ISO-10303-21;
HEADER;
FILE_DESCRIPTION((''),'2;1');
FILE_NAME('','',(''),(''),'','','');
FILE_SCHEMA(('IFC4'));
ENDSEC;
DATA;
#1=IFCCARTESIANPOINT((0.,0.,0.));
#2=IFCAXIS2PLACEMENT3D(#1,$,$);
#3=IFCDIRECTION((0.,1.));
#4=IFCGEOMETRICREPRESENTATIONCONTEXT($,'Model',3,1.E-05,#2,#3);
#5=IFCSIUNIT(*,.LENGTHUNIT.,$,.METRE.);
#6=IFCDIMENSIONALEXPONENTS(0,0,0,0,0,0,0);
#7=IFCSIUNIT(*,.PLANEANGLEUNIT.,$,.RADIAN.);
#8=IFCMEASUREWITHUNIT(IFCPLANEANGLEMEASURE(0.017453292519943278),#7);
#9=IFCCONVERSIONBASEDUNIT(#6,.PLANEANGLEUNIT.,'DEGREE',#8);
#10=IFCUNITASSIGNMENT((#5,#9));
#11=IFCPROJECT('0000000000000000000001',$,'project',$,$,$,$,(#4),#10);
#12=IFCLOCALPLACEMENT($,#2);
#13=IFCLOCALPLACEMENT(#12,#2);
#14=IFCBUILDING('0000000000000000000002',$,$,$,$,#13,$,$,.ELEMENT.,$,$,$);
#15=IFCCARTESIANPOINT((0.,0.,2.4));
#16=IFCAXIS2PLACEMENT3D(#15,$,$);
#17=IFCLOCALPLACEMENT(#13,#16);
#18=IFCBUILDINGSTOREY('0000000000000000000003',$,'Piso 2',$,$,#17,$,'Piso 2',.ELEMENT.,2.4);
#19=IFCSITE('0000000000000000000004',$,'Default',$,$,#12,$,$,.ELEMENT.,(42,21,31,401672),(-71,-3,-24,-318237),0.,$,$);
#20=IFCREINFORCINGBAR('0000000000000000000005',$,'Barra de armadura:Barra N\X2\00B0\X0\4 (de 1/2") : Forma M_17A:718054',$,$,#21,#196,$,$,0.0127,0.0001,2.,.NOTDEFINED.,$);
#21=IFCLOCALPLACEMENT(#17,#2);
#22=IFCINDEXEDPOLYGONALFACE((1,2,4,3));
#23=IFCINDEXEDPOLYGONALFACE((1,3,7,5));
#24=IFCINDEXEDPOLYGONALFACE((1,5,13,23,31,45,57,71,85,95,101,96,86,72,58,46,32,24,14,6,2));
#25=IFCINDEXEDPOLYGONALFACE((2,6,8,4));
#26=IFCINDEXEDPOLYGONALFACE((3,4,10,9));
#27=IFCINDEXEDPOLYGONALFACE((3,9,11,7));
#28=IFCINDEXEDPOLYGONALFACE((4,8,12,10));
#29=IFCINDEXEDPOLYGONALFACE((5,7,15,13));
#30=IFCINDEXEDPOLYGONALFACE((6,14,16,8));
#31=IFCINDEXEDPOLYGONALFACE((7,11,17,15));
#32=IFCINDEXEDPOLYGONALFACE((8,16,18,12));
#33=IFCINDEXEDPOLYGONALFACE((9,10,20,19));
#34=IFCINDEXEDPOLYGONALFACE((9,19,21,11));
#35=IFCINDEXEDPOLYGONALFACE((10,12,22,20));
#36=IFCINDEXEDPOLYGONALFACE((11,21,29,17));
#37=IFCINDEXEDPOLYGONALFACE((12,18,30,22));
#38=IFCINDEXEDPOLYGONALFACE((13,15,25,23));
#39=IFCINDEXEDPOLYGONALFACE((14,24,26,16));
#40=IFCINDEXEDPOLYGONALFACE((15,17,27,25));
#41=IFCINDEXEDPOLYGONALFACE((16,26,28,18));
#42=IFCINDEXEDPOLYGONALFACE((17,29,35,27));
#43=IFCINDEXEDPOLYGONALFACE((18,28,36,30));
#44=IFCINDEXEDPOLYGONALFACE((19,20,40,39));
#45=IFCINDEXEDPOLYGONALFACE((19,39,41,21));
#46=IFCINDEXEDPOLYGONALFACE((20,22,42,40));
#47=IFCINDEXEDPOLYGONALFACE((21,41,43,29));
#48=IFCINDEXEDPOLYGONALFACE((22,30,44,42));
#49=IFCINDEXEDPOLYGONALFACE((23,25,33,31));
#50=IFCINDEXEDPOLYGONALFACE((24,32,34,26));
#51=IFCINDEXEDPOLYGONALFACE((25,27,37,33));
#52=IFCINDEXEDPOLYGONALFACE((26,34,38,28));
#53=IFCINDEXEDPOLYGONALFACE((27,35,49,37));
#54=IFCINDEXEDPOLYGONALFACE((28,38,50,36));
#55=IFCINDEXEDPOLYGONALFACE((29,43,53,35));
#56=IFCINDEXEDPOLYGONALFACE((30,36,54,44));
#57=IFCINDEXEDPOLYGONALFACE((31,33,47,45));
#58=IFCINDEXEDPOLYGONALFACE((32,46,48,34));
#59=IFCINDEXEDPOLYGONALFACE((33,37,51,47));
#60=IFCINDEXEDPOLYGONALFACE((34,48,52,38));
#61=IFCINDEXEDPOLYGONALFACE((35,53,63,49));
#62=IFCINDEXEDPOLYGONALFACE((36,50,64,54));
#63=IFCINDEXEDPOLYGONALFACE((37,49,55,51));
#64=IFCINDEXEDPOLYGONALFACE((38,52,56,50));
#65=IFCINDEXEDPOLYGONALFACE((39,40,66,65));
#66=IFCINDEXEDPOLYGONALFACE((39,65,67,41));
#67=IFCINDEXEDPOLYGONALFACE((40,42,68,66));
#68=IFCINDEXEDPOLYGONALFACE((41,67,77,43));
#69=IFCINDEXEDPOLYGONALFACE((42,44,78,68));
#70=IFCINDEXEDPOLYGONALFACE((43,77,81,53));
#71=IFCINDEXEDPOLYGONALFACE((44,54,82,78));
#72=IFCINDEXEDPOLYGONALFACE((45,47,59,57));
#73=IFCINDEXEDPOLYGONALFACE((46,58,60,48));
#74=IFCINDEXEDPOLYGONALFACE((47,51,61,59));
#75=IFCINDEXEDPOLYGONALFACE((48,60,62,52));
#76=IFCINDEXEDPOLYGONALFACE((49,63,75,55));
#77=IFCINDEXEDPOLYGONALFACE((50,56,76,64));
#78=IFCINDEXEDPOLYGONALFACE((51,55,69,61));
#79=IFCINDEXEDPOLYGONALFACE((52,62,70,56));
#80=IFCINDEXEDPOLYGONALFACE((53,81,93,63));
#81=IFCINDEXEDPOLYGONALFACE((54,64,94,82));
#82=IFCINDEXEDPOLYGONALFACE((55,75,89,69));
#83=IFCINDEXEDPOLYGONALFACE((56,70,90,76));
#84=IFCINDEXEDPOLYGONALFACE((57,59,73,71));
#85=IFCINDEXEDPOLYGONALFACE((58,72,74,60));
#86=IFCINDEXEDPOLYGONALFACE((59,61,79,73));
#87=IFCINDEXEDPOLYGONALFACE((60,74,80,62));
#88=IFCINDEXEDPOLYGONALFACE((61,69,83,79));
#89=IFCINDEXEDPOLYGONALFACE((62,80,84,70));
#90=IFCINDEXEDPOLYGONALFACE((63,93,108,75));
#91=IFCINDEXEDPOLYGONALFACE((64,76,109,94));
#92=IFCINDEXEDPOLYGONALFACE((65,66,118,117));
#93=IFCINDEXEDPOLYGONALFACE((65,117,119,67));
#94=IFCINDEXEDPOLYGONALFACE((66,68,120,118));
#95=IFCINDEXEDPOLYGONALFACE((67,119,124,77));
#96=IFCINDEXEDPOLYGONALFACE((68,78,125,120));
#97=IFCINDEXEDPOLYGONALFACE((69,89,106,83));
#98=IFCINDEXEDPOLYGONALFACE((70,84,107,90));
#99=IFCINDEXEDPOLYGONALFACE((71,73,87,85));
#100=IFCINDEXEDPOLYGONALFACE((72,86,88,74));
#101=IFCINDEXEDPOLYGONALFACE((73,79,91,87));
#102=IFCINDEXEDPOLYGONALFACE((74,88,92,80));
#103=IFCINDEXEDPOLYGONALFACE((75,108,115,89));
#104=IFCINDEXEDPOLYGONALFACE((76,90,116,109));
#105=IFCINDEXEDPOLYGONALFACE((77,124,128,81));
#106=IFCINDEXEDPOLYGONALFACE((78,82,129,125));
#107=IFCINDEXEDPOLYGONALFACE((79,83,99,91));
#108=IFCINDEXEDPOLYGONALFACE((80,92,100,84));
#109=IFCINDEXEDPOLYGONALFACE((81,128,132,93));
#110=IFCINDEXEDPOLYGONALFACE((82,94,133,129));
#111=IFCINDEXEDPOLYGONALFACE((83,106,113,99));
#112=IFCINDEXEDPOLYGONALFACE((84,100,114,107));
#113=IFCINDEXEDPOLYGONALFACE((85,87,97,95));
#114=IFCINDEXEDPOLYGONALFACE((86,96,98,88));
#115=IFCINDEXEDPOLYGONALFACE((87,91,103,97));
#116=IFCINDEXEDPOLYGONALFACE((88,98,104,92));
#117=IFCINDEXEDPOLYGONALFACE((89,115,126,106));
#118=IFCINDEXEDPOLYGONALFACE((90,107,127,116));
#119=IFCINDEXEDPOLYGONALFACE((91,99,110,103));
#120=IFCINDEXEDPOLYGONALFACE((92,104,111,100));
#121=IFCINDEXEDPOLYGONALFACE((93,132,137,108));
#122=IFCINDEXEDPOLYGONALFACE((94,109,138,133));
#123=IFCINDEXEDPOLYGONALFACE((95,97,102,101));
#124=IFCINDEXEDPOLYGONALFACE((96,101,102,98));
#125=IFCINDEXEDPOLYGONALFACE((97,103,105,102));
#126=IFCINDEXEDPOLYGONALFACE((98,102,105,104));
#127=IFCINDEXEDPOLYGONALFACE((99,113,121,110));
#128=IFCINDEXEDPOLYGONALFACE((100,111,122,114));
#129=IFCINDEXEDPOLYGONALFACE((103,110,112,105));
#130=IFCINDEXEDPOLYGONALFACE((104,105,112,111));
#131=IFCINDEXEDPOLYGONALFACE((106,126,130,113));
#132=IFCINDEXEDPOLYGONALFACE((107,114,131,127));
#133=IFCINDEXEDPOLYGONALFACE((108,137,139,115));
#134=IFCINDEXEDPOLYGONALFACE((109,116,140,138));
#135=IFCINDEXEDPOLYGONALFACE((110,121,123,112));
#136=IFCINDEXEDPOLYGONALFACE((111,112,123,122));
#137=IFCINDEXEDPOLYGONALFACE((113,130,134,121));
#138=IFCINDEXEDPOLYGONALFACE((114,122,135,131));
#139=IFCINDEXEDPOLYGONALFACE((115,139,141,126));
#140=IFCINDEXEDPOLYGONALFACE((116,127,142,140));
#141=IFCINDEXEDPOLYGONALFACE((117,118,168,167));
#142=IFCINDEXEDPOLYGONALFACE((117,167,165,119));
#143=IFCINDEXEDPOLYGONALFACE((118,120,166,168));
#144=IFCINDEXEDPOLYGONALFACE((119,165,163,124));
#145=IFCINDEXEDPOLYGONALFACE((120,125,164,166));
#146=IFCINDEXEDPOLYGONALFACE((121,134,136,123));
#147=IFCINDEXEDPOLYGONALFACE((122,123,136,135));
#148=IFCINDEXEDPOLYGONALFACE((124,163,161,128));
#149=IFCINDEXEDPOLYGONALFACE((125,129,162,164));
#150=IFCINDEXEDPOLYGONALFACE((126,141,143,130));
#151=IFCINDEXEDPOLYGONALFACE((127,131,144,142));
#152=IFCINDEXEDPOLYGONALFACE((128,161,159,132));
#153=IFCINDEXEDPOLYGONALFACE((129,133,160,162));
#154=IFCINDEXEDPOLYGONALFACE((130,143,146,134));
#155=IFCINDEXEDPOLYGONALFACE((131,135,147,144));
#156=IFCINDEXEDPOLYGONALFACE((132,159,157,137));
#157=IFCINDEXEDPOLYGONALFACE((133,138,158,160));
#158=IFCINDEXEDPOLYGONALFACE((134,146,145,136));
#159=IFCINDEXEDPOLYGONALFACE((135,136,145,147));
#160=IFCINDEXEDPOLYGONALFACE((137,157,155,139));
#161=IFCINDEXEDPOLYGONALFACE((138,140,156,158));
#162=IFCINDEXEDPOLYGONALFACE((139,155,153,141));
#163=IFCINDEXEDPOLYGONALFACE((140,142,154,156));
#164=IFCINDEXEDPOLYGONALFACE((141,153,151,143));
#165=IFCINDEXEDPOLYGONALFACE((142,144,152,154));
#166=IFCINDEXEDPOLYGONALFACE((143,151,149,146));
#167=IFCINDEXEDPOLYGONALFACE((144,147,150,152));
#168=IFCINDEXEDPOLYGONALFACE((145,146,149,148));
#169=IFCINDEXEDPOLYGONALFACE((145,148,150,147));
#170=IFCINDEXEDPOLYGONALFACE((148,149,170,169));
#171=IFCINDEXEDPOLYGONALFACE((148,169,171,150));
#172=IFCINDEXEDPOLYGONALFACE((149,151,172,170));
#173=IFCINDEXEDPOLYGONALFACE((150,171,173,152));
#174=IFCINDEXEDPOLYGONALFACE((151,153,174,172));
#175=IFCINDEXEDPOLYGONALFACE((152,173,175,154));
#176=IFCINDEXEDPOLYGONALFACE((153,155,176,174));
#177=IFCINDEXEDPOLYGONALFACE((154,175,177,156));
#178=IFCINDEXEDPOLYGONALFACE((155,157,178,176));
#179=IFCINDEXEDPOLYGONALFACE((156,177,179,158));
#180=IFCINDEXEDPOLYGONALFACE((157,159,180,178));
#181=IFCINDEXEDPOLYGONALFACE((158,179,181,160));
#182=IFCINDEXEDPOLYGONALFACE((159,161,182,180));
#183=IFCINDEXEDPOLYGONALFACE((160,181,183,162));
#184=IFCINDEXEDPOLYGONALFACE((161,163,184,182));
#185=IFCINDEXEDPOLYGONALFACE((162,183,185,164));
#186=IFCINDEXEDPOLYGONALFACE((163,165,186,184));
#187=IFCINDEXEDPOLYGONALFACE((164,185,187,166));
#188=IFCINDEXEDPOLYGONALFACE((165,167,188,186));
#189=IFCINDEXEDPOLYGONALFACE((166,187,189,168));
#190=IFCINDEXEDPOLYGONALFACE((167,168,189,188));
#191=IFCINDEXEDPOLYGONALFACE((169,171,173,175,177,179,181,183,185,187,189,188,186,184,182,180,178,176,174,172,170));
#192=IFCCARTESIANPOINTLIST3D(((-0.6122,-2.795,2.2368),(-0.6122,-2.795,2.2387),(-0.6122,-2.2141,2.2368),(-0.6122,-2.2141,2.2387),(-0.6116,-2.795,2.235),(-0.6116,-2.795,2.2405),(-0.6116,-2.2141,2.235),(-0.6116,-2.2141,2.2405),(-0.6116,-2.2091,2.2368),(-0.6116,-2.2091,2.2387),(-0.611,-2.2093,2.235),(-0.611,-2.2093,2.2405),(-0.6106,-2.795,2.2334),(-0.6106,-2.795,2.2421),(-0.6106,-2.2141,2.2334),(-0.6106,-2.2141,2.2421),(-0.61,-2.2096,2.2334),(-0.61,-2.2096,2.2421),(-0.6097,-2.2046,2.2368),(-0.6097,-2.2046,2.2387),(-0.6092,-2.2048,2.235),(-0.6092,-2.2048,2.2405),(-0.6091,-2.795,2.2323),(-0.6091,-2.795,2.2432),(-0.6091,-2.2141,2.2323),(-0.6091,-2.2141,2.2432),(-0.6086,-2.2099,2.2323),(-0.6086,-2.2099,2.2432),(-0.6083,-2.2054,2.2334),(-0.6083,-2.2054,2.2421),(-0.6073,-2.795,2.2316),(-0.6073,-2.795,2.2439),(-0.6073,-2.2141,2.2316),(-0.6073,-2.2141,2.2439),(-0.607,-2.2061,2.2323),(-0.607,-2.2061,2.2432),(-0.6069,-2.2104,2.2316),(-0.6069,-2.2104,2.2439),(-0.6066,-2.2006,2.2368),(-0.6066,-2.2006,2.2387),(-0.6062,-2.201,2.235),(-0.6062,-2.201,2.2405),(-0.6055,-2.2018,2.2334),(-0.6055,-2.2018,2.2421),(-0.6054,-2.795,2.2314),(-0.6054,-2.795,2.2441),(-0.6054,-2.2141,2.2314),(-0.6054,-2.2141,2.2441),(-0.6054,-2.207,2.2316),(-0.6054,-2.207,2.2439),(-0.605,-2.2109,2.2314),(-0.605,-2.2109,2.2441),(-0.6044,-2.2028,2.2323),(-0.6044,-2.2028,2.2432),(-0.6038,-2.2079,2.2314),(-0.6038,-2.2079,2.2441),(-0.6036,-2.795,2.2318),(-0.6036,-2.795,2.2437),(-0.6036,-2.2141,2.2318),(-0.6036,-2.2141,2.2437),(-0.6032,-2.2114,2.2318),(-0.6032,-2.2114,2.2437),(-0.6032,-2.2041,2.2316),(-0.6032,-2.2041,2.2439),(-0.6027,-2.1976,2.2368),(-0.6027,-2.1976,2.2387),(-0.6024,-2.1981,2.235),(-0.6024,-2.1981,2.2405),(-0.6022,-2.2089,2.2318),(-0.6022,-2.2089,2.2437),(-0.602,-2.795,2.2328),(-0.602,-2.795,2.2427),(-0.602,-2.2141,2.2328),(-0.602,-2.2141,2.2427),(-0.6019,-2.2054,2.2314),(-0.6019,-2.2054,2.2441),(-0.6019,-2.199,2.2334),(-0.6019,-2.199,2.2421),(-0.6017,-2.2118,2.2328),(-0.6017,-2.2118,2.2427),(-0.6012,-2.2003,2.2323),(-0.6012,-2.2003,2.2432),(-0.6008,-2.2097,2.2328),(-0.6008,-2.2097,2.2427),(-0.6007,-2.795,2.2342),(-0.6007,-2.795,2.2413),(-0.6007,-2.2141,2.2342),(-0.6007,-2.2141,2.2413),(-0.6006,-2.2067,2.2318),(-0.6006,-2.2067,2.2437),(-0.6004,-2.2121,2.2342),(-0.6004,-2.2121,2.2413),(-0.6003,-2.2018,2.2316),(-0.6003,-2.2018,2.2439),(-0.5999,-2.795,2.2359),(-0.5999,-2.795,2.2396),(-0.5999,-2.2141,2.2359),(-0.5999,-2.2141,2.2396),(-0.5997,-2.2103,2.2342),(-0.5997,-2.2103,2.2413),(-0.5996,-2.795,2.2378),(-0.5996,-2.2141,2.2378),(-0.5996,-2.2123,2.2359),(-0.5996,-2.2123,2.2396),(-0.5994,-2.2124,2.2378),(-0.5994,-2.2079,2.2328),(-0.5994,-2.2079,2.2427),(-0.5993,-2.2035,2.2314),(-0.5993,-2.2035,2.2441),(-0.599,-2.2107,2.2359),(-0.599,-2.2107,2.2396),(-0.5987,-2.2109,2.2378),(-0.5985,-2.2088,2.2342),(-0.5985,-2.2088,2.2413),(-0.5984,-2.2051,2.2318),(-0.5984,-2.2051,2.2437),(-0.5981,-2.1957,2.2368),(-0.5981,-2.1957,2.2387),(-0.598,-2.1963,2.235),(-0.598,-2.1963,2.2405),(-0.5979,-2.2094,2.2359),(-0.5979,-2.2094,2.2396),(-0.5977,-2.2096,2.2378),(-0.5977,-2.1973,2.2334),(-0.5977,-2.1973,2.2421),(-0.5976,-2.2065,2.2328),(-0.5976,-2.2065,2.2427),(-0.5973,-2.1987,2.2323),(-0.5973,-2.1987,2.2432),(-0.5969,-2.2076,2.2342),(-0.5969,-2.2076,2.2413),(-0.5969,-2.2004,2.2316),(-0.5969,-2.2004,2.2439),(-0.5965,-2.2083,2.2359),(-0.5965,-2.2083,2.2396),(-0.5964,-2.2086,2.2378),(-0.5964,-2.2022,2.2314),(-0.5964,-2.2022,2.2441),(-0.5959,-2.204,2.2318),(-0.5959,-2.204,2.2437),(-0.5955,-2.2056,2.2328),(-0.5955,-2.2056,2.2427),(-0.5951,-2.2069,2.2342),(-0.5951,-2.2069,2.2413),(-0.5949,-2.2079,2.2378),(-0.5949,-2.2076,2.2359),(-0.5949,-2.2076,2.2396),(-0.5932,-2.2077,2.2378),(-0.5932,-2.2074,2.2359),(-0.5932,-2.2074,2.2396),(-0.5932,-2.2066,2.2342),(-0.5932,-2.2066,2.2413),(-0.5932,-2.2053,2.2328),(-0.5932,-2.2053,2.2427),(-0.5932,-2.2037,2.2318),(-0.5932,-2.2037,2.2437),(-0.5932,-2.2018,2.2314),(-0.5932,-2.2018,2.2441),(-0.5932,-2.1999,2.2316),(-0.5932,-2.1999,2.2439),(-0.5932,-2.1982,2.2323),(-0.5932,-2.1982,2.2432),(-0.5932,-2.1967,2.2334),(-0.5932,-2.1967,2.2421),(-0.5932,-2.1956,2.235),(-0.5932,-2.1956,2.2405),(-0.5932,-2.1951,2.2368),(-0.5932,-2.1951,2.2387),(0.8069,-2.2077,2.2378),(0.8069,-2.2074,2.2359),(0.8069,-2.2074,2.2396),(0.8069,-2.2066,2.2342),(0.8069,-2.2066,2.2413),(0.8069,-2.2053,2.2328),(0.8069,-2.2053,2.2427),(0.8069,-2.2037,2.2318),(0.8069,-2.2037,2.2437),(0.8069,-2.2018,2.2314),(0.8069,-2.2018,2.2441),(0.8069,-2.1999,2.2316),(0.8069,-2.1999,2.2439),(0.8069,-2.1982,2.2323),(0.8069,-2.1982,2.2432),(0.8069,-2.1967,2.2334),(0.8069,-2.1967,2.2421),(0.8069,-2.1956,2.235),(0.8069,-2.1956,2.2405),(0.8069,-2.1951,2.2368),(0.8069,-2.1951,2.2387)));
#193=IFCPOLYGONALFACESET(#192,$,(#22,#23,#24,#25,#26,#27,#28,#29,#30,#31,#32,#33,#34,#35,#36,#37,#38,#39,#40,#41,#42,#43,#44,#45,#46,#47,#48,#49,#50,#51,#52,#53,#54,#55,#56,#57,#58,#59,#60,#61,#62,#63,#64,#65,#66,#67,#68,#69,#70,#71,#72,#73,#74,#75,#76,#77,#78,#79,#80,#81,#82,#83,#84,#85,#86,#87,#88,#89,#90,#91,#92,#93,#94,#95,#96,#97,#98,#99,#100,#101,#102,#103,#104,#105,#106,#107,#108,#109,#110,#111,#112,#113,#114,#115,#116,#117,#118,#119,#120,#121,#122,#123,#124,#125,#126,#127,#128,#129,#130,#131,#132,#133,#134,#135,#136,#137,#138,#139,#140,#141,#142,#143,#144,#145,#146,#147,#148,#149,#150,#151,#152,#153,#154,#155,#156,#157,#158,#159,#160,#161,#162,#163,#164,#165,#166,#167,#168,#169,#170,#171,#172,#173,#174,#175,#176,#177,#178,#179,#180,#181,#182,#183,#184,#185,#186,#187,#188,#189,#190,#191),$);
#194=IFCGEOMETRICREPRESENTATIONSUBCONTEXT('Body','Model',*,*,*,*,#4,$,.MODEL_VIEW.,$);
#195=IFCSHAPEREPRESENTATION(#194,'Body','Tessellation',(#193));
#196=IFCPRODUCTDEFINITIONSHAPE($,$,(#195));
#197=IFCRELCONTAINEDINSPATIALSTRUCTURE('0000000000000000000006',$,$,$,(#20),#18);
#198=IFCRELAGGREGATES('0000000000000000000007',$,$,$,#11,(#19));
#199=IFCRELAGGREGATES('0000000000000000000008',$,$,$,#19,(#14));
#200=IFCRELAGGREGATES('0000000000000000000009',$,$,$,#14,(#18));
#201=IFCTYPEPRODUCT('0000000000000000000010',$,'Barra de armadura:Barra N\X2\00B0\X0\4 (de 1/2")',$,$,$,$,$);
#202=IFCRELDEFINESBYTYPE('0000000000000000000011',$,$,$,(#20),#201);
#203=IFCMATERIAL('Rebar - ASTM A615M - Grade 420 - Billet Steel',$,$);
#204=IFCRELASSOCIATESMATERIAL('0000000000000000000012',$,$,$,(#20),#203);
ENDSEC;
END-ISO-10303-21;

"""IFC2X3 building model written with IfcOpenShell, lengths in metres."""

from ifc_helpers import new_model, entity, si_unit, converted_unit, direction, frame, origin, place, context, subcontext, project, spatial, material, type_object, element, save


model = new_model("IFC2X3")

# Units and contexts
model_context = context("Model", 3, precision=1e-05, world=origin(), true_north=direction((0.0, 1.0)))
body_context = subcontext(model_context, "Body", "Model", "MODEL_VIEW")
ifc_project = project(units=[si_unit("LENGTHUNIT", "METRE"), converted_unit("PLANEANGLEUNIT", "DEGREE", entity("IfcPlaneAngleMeasure", 0.017453292519943278), si_unit("PLANEANGLEUNIT", "RADIAN"), dimensions=[0, 0, 0, 0, 0, 0, 0])], contexts=[model_context])

# Site, building, storey
site_placement = place(None, origin())
site = spatial("IfcSite", under=ifc_project, at=site_placement, Name="Default", CompositionType="ELEMENT", RefLatitude=(42, 21, 31, 401672), RefLongitude=(-71, -3, -24, -318237), RefElevation=0.0)
building_placement = place(site_placement, origin())
building = spatial("IfcBuilding", under=site, at=building_placement, CompositionType="ELEMENT")
storey_placement = place(building_placement, frame((0.0, 0.0, 2.4)))
storey = spatial("IfcBuildingStorey", under=building, at=storey_placement, Name="Piso 2", LongName="Piso 2", CompositionType="ELEMENT", Elevation=2.4)

# Reinforcing bar
ifc_material_1 = material(Name="Rebar - ASTM A615M - Grade 420 - Billet Steel")
type_product_1 = type_object("IfcTypeProduct", Name="Barra de armadura:Barra N°4 (de 1/2\")")
reinforcing_bar_1_placement = place(storey_placement, origin())
element("IfcReinforcingBar", 1, at=reinforcing_bar_1_placement, inside=storey, type_object=type_product_1, material=ifc_material_1, Name="Barra de armadura:Barra N°4 (de 1/2\") : Forma M_17A:718054", BarLength=2.0, BarRole="NOTDEFINED", CrossSectionArea=0.0001, NominalDiameter=0.0127, context=body_context, shape_type="AdvancedSweptSolid", body=[
    entity("IfcSweptDiskSolid", entity("IfcCompositeCurve", [entity("IfcCompositeCurveSegment", "CONTINUOUS", True, entity("IfcPolyline", [entity("IfcCartesianPoint", [0.8069, -2.2014, 2.2378]), entity("IfcCartesianPoint", [-0.5932, -2.2014, 2.2378])])), entity("IfcCompositeCurveSegment", "CONTINUOUS", True, entity("IfcTrimmedCurve", entity("IfcCircle", entity("IfcAxis2Placement3D", entity("IfcCartesianPoint", [-0.5932, -2.2141, 2.2378]), entity("IfcDirection", [0.0, 0.0, 1.0]), entity("IfcDirection", [-1.0, 0.0, 0.0])), 0.0127), [entity("IfcParameterValue", 270.0)], [entity("IfcParameterValue", 360.0)], True, "PARAMETER")), entity("IfcCompositeCurveSegment", "CONTINUOUS", True, entity("IfcPolyline", [entity("IfcCartesianPoint", [-0.6059, -2.2141, 2.2378]), entity("IfcCartesianPoint", [-0.6059, -2.795, 2.2378])]))], False), 0.0063, None, 0.0, 92.0),
])

save(model, "model.ifc")
